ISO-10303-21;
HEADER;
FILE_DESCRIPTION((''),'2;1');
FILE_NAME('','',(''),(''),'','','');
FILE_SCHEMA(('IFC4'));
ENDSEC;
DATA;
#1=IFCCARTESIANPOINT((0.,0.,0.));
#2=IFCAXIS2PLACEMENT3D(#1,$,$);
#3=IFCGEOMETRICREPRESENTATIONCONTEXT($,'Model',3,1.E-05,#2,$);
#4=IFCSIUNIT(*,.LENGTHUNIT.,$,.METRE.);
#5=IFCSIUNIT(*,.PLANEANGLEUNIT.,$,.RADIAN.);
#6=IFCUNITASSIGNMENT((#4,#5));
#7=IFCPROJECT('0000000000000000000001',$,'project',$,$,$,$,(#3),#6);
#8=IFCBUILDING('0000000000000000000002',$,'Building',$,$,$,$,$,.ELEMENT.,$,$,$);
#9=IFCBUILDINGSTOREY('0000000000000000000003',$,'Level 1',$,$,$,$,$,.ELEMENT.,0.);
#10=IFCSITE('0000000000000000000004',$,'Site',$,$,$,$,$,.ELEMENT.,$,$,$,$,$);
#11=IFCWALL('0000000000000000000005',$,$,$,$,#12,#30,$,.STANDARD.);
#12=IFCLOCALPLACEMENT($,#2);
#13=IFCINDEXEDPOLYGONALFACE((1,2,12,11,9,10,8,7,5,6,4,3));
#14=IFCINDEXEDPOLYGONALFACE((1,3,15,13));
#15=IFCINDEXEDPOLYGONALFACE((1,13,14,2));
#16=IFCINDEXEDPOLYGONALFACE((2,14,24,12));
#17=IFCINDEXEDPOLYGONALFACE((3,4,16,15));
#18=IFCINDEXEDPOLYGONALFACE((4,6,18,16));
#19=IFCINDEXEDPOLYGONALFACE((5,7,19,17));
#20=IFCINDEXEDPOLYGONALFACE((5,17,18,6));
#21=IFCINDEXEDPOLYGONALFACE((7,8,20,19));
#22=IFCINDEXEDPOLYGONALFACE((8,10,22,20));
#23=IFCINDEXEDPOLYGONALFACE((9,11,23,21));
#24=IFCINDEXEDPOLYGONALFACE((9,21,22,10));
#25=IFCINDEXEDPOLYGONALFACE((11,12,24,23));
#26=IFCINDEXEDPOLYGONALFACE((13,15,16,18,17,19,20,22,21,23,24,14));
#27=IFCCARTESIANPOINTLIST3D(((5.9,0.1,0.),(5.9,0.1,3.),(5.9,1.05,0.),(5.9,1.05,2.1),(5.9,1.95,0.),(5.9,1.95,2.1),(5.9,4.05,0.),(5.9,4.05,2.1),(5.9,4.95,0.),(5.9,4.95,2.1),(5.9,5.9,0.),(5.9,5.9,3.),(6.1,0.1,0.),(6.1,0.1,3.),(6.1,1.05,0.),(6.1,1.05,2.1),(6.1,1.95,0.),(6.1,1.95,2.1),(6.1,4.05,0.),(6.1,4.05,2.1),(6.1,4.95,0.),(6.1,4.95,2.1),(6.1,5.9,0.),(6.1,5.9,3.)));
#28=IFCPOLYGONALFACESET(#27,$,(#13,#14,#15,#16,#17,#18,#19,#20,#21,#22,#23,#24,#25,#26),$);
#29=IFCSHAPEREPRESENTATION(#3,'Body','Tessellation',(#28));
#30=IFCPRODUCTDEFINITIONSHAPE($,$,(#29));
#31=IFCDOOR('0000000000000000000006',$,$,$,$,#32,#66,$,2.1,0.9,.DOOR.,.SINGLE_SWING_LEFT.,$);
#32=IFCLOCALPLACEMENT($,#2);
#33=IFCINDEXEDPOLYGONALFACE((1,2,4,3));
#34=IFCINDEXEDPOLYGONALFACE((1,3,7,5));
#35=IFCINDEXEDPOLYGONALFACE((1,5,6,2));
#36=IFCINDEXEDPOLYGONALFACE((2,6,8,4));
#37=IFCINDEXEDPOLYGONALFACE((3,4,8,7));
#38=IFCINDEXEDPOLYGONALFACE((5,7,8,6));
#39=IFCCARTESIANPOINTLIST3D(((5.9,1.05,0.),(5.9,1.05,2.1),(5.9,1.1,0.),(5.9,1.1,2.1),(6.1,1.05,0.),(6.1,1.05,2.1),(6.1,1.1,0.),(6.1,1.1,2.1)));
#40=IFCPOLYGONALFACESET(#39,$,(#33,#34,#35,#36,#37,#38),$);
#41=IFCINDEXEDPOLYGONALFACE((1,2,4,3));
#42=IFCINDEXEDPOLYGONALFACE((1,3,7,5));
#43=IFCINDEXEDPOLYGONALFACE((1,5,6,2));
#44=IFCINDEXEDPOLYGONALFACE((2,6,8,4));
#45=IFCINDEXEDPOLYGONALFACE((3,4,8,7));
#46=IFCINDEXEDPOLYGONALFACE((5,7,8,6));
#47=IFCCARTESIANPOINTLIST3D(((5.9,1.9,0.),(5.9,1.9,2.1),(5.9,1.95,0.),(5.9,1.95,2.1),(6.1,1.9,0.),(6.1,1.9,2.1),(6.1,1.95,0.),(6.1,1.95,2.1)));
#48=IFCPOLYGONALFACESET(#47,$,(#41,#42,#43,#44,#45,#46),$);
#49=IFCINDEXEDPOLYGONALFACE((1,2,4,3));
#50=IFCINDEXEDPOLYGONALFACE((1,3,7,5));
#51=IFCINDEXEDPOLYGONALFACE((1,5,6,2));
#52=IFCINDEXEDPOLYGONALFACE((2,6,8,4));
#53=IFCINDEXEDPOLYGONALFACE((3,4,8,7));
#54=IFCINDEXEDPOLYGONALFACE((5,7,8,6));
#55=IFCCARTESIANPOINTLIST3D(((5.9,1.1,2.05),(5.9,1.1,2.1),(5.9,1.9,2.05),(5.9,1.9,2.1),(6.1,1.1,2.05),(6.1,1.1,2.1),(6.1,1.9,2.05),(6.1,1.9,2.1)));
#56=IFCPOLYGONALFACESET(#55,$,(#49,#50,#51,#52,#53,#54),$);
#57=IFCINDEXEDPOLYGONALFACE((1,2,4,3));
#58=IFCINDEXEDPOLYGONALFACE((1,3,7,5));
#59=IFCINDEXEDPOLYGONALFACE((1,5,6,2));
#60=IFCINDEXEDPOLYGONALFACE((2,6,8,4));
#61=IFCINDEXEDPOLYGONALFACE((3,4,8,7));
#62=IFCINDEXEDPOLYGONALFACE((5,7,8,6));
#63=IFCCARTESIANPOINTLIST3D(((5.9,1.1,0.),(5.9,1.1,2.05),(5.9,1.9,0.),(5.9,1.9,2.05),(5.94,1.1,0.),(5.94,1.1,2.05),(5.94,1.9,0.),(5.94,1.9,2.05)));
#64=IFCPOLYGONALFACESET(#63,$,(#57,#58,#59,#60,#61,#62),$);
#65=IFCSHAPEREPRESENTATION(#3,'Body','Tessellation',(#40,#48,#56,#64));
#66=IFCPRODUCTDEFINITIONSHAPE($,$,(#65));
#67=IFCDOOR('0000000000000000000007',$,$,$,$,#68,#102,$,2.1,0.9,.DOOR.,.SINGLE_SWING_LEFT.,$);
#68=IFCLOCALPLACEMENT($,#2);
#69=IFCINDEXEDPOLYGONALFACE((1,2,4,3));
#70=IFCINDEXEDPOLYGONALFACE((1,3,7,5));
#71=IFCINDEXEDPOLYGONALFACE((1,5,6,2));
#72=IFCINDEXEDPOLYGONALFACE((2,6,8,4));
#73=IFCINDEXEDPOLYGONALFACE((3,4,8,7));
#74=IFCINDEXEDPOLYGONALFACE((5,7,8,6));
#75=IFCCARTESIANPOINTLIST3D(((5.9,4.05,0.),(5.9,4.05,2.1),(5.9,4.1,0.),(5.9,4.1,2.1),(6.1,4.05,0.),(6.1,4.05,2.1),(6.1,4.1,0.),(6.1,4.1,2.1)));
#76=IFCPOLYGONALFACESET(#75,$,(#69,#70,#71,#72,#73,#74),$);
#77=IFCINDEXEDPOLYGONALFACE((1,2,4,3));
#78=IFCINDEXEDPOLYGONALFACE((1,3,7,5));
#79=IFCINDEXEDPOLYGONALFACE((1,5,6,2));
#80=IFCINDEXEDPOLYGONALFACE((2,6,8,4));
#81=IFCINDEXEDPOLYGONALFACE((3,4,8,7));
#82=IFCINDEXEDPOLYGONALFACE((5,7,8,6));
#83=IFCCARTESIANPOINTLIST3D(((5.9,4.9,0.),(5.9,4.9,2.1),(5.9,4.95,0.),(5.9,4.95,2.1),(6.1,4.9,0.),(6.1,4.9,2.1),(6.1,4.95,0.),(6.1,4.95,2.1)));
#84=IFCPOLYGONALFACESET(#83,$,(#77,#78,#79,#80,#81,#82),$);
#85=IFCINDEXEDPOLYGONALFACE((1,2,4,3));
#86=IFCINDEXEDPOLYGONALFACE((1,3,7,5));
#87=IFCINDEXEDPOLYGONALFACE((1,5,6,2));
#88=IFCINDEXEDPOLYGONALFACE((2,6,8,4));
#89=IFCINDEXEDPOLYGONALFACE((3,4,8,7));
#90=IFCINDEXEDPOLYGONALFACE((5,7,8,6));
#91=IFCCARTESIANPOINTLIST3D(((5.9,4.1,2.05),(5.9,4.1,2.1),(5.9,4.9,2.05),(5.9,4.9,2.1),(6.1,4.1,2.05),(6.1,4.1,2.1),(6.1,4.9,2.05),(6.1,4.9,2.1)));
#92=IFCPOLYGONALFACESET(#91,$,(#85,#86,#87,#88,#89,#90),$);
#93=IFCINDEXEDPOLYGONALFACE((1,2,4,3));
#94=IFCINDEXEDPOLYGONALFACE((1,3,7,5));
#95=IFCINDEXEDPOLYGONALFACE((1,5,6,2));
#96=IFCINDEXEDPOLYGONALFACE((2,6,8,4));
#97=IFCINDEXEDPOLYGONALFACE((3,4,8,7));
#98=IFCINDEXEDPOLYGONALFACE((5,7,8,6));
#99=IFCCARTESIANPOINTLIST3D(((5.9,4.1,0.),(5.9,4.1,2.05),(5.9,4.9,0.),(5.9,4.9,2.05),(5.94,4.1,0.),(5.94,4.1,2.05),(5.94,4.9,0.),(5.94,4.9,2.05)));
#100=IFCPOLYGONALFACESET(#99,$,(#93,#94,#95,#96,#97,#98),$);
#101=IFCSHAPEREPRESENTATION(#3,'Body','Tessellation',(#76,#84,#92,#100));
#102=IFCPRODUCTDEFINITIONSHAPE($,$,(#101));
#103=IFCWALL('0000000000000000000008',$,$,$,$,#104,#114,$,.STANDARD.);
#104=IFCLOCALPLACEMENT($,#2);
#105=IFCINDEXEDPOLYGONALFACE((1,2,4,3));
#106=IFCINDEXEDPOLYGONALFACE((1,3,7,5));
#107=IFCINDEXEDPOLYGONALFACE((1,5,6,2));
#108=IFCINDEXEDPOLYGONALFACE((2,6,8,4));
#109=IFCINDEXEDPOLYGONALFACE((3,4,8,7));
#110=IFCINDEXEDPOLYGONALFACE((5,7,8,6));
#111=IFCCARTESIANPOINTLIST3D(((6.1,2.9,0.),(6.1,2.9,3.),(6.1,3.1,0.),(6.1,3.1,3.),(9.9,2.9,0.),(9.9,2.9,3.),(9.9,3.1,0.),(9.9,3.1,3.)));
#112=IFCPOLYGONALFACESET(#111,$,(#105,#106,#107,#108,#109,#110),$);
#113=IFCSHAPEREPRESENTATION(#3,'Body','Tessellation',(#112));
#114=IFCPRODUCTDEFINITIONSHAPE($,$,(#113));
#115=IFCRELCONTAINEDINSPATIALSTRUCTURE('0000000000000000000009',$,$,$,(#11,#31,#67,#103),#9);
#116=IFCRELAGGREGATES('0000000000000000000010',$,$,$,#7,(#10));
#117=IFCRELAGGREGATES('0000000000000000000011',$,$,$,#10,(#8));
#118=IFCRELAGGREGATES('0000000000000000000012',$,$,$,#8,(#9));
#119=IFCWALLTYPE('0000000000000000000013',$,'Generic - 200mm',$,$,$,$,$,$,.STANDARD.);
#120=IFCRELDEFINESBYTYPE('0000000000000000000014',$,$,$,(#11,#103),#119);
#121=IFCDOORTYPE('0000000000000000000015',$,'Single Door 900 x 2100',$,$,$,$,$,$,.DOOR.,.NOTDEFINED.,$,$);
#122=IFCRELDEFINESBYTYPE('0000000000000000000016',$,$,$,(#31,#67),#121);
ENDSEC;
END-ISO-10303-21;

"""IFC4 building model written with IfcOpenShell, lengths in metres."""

from ifc_helpers import new_model, si_unit, frame, frame_2d, origin, origin_with_axes, origin_2d, place, context, project, spatial, polyline, rectangle, outline, extrude, type_object, element, fill, save


model = new_model("IFC4")

# Units and contexts
model_context = context("Model", 3, precision=1e-05, world=origin())
ifc_project = project(units=[si_unit("LENGTHUNIT", "METRE"), si_unit("PLANEANGLEUNIT", "RADIAN")], contexts=[model_context])

# Site, building, storey
site = spatial("IfcSite", under=ifc_project, Name="Site", CompositionType="ELEMENT")
building = spatial("IfcBuilding", under=site, Name="Building", CompositionType="ELEMENT")
storey = spatial("IfcBuildingStorey", under=building, Name="Level 1", CompositionType="ELEMENT", Elevation=0.0)

# Shared definitions
wall_type = type_object("IfcWallType", Name="Generic - 200mm", PredefinedType="STANDARD")
door_type = type_object("IfcDoorType", Name="Single Door 900 x 2100", OperationType="NOTDEFINED", PredefinedType="DOOR")

# Wall, openings, doors
wall_1_placement = place(None, frame((6.0, 0.0, 0.0), z_axis=(0.0, 0.0, 1.0), x_axis=(0.0, 1.0, 0.0)))
wall_1 = element("IfcWall", 1, at=wall_1_placement, inside=storey, type_object=wall_type, PredefinedType="STANDARD", context=model_context, shape_type="SweptSolid", body=[
    extrude(outline(polyline([(0.1, -0.1), (5.9, -0.1), (5.9, 0.1), (0.1, 0.1), (0.1, -0.1)])), origin(), (0.0, 0.0, 1.0), 3.0),
])
opening_1_placement = place(wall_1_placement, frame((1.5, 0.0, 0.0), z_axis=(0.0, 0.0, 1.0), x_axis=(1.0, 0.0, 0.0)))
opening_1 = element("IfcOpeningElement", 2, at=opening_1_placement, cuts=wall_1, PredefinedType="OPENING", context=model_context, shape_type="SweptSolid", body=[
    extrude(rectangle(XDim=0.9, YDim=0.202, at=origin_2d()), origin(), (0.0, 0.0, 1.0), 2.1),
])
opening_2_placement = place(wall_1_placement, frame((4.5, 0.0, 0.0), z_axis=(0.0, 0.0, 1.0), x_axis=(1.0, 0.0, 0.0)))
opening_2 = element("IfcOpeningElement", 3, at=opening_2_placement, cuts=wall_1, PredefinedType="OPENING", context=model_context, shape_type="SweptSolid", body=[
    extrude(rectangle(XDim=0.9, YDim=0.202, at=origin_2d()), origin(), (0.0, 0.0, 1.0), 2.1),
])
door_1_placement = place(opening_1_placement, origin_with_axes())
door_1 = element("IfcDoor", 4, at=door_1_placement, inside=storey, type_object=door_type, OperationType="SINGLE_SWING_LEFT", OverallHeight=2.1, OverallWidth=0.9, PredefinedType="DOOR", context=model_context, shape_type="SweptSolid", body=[
    extrude(rectangle(XDim=0.05, YDim=0.2, at=frame_2d((-0.425, 0.0))), origin(), (0.0, 0.0, 1.0), 2.1),
    extrude(rectangle(XDim=0.05, YDim=0.2, at=frame_2d((0.425, 0.0))), origin(), (0.0, 0.0, 1.0), 2.1),
    extrude(rectangle(XDim=0.8, YDim=0.2, at=origin_2d()), frame((0.0, 0.0, 2.05)), (0.0, 0.0, 1.0), 0.05),
    extrude(rectangle(XDim=0.8, YDim=0.04, at=frame_2d((0.0, 0.08))), origin(), (0.0, 0.0, 1.0), 2.05),
])
fill(opening_1, door_1)
door_2_placement = place(opening_2_placement, origin_with_axes())
door_2 = element("IfcDoor", 5, at=door_2_placement, inside=storey, type_object=door_type, OperationType="SINGLE_SWING_LEFT", OverallHeight=2.1, OverallWidth=0.9, PredefinedType="DOOR", context=model_context, shape_type="SweptSolid", body=[
    extrude(rectangle(XDim=0.05, YDim=0.2, at=frame_2d((-0.425, 0.0))), origin(), (0.0, 0.0, 1.0), 2.1),
    extrude(rectangle(XDim=0.05, YDim=0.2, at=frame_2d((0.425, 0.0))), origin(), (0.0, 0.0, 1.0), 2.1),
    extrude(rectangle(XDim=0.8, YDim=0.2, at=origin_2d()), frame((0.0, 0.0, 2.05)), (0.0, 0.0, 1.0), 0.05),
    extrude(rectangle(XDim=0.8, YDim=0.04, at=frame_2d((0.0, 0.08))), origin(), (0.0, 0.0, 1.0), 2.05),
])
fill(opening_2, door_2)

# Wall
wall_2_placement = place(None, frame((6.0, 3.0, 0.0), z_axis=(0.0, 0.0, 1.0), x_axis=(1.0, 0.0, 0.0)))
element("IfcWall", 6, at=wall_2_placement, inside=storey, type_object=wall_type, PredefinedType="STANDARD", context=model_context, shape_type="SweptSolid", body=[
    extrude(outline(polyline([(0.1, -0.1), (3.9, -0.1), (3.9, 0.1), (0.1, 0.1), (0.1, -0.1)])), origin(), (0.0, 0.0, 1.0), 3.0),
])

save(model, "model.ifc")
